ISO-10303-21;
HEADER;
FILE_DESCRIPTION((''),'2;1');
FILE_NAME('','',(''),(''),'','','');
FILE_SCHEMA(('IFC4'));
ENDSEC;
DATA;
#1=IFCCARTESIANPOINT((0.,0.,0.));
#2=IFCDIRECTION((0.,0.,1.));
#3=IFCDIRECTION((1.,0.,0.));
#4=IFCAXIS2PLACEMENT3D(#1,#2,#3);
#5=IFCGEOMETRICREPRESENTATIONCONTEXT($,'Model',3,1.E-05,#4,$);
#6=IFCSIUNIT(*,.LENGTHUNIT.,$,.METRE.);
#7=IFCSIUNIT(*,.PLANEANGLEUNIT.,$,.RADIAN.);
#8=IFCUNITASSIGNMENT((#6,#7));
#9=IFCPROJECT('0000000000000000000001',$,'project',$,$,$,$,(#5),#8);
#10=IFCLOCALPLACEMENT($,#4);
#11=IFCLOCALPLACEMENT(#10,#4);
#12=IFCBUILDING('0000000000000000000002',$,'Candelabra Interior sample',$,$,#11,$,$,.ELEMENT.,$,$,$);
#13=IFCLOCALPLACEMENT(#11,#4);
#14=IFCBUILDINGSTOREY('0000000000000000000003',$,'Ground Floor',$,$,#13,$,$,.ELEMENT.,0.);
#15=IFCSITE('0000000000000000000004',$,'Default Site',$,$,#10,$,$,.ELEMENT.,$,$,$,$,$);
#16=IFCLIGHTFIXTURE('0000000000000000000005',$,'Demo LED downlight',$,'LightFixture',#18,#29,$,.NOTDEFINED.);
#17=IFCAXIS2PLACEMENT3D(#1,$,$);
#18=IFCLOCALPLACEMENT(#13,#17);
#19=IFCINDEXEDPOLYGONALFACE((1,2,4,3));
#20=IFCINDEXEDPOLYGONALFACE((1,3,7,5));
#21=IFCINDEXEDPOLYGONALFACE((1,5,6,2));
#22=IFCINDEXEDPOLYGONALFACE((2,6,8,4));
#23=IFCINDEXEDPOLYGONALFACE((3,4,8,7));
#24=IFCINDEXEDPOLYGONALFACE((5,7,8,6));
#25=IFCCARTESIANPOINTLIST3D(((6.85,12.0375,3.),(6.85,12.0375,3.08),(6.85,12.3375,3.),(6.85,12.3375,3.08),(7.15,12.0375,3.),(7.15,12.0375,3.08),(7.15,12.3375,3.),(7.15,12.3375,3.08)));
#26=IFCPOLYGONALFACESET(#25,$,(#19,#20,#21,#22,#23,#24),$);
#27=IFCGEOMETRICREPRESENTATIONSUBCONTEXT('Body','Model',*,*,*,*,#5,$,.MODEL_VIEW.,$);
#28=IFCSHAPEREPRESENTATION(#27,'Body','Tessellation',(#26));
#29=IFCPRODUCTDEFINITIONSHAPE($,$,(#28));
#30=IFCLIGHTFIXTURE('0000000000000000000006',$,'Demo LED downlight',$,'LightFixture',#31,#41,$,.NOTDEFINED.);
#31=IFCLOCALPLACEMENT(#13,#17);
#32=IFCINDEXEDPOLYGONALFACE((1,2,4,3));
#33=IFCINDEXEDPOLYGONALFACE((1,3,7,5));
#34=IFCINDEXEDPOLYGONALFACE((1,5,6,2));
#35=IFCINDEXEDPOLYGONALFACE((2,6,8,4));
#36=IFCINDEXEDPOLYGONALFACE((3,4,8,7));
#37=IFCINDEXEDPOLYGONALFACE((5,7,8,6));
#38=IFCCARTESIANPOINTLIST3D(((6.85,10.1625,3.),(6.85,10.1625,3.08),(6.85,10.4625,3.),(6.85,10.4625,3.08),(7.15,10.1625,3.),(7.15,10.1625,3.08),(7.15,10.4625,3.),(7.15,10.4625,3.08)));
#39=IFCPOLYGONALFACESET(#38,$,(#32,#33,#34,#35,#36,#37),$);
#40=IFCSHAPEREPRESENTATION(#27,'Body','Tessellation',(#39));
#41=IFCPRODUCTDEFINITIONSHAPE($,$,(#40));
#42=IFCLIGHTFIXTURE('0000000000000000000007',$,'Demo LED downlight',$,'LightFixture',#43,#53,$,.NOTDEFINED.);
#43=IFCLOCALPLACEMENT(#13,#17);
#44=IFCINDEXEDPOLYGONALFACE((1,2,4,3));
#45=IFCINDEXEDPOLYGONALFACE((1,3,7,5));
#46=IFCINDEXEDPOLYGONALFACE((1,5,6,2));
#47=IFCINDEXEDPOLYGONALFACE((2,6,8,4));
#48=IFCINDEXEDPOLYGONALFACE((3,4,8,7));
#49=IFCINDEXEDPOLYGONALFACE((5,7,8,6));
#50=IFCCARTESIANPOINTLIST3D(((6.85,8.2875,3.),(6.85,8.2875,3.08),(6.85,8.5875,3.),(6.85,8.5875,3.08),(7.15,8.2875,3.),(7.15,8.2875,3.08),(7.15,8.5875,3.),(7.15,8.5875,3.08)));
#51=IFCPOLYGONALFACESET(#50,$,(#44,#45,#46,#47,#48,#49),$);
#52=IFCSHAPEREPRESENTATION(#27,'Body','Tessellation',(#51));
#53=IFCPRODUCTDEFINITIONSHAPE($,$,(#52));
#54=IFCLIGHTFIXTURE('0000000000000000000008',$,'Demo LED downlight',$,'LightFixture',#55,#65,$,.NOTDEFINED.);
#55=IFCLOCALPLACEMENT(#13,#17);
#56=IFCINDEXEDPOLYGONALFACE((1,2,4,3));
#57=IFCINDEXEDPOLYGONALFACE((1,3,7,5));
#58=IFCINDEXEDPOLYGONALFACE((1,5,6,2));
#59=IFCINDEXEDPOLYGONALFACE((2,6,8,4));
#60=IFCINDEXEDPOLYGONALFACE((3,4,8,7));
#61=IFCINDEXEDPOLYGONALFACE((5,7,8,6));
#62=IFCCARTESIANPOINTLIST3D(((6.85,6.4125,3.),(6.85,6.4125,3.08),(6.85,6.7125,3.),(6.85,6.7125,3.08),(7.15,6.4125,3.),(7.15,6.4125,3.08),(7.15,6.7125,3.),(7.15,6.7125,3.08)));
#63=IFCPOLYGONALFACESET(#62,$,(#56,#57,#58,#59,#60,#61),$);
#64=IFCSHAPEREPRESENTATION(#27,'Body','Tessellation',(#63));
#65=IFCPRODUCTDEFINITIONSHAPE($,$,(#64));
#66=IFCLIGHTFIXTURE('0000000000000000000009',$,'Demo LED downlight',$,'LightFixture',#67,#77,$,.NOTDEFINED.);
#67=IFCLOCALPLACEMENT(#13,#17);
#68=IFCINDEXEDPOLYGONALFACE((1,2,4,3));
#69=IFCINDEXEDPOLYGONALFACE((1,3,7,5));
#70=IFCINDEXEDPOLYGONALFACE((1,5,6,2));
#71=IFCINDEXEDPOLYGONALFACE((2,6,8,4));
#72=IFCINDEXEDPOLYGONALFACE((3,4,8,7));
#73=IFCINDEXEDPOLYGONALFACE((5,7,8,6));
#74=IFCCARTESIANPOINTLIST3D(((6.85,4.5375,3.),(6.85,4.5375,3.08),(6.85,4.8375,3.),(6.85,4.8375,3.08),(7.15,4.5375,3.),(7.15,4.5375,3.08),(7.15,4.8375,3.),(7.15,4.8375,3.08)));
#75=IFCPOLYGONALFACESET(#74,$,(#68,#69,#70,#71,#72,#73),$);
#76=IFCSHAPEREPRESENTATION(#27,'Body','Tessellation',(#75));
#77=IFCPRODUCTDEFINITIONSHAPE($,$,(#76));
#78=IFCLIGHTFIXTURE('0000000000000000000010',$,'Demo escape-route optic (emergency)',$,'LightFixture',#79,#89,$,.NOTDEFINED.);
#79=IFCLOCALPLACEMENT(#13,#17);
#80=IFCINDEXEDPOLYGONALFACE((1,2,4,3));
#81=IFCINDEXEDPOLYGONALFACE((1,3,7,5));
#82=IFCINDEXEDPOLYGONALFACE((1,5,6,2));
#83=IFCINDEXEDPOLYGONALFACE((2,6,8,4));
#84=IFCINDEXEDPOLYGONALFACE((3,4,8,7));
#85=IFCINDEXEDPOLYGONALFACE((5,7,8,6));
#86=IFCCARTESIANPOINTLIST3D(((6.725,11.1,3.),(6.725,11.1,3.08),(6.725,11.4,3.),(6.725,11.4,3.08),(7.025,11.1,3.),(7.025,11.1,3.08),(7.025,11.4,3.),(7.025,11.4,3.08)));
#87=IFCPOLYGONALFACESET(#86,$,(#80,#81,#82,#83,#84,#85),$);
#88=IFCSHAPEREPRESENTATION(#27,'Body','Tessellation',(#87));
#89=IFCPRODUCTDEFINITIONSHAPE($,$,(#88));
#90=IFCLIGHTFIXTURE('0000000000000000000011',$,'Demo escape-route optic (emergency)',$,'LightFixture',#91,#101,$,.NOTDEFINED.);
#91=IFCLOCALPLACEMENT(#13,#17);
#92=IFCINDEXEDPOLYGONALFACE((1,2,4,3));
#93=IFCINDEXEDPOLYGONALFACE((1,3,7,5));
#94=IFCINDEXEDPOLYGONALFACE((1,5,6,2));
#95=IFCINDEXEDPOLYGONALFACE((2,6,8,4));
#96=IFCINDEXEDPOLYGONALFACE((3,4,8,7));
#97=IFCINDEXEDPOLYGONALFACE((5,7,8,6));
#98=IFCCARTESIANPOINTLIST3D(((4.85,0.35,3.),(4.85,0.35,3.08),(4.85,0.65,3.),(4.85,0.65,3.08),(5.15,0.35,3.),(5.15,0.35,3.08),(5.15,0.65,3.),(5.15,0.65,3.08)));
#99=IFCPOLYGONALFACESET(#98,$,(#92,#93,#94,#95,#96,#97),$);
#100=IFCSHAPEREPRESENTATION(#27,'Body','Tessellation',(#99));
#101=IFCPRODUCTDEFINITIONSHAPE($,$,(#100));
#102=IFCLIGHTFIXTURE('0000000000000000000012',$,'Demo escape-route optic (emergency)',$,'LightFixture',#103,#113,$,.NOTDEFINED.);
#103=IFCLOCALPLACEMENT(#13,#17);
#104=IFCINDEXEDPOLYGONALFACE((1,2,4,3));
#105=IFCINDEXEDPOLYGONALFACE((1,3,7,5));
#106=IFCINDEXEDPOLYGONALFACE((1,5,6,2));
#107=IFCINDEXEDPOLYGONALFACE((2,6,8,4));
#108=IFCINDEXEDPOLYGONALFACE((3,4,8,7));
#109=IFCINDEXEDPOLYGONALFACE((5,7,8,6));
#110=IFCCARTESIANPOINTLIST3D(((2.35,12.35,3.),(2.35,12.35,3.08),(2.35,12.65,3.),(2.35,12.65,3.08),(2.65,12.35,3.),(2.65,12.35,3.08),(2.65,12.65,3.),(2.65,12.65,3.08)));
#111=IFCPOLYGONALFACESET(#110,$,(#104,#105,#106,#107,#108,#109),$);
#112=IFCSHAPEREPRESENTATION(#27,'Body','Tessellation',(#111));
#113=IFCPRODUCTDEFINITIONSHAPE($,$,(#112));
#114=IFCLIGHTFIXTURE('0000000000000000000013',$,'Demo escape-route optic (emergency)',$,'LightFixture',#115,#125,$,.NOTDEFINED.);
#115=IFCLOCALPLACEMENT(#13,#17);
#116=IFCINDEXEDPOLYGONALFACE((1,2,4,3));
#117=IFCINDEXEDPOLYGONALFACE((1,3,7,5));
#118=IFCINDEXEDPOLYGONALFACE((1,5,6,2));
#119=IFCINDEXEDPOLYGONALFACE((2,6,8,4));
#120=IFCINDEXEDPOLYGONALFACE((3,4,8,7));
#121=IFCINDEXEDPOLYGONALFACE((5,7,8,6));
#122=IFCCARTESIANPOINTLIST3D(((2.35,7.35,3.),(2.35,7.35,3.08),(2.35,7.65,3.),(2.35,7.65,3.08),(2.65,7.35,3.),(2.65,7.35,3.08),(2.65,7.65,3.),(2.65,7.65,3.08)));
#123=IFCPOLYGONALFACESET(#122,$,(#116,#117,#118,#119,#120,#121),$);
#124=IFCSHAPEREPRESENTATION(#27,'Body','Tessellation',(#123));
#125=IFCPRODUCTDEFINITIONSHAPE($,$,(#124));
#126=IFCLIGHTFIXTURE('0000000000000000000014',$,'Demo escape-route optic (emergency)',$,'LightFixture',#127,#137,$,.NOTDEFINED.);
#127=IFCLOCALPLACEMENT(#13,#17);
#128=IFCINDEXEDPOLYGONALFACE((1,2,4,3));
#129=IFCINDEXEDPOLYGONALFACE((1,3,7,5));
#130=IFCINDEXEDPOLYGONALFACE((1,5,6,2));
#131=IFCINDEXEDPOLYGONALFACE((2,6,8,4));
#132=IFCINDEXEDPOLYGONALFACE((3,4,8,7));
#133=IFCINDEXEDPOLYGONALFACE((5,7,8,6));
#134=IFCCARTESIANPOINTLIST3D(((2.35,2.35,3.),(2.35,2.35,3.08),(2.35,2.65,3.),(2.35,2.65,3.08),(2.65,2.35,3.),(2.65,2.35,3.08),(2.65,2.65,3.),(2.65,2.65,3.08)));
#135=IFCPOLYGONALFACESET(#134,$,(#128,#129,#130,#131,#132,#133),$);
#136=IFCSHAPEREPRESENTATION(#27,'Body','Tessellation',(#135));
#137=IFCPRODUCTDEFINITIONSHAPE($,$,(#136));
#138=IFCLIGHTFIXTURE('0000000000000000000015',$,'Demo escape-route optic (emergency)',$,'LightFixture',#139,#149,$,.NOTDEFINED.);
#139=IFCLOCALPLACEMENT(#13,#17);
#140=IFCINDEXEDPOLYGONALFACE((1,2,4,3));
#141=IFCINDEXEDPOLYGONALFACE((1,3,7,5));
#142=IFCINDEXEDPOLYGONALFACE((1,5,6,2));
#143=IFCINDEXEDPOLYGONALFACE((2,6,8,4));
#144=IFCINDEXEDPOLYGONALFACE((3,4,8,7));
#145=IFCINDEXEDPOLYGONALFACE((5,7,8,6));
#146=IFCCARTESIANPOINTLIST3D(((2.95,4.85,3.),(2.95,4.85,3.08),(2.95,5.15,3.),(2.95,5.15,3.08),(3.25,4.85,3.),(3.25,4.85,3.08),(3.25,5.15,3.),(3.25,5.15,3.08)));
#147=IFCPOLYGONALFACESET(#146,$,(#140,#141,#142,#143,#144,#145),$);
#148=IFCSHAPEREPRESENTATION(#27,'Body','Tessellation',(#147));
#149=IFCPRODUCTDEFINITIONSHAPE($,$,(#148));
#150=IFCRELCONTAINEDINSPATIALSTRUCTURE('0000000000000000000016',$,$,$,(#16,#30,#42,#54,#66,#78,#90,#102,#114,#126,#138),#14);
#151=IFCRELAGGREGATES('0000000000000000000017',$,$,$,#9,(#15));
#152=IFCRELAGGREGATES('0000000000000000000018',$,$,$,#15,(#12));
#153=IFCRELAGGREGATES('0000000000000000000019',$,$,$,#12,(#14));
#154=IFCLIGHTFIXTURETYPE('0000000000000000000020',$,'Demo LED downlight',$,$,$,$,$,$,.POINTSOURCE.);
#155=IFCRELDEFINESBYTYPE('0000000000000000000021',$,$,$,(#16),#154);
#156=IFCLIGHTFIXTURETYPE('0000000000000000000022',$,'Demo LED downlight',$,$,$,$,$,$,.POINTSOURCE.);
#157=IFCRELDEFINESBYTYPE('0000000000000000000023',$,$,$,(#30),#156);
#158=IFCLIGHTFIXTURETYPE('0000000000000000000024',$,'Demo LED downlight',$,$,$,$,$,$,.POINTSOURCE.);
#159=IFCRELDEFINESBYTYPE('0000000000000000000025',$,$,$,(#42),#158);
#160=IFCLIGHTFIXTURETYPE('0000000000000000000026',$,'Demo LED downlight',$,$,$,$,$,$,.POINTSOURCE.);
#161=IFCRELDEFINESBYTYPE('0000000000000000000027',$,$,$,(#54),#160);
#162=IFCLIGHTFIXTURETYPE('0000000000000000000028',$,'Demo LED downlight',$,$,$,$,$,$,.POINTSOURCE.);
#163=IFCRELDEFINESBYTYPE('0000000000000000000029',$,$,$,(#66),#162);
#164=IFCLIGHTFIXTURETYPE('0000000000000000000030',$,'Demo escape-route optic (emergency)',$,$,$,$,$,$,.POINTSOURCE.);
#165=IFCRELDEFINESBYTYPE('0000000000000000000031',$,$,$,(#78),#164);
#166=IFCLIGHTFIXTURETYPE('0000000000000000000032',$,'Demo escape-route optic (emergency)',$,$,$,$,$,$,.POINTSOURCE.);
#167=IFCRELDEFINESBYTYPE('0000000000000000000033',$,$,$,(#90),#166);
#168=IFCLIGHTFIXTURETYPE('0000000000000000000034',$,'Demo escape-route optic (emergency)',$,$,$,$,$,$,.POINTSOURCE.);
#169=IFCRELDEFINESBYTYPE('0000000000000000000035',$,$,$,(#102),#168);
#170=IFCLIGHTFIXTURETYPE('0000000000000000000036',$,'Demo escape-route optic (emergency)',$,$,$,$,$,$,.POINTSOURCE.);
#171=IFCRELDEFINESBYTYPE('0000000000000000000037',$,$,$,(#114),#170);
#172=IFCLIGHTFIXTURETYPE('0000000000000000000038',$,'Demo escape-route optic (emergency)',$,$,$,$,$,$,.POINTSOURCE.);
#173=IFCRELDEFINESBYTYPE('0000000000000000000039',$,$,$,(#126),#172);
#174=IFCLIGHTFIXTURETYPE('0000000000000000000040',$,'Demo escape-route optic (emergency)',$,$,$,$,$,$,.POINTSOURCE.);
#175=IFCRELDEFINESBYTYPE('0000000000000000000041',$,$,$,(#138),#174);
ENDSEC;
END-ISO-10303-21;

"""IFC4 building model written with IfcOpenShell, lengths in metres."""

from ifc_helpers import new_model, si_unit, frame, origin_with_axes, place, context, subcontext, project, spatial, polyline, outline, extrude, type_object, element, save


model = new_model("IFC4")

# Units and contexts
model_context = context("Model", 3, precision=1e-05, world=origin_with_axes())
body_context = subcontext(model_context, "Body", "Model", "MODEL_VIEW")
ifc_project = project(units=[si_unit("LENGTHUNIT", "METRE"), si_unit("PLANEANGLEUNIT", "RADIAN")], contexts=[model_context])

# Site, building, storey
site_placement = place(None, origin_with_axes())
site = spatial("IfcSite", under=ifc_project, at=site_placement, Name="Default Site", CompositionType="ELEMENT")
building_placement = place(site_placement, origin_with_axes())
building = spatial("IfcBuilding", under=site, at=building_placement, Name="Candelabra Interior sample", CompositionType="ELEMENT")
storey_placement = place(building_placement, origin_with_axes())
storey = spatial("IfcBuildingStorey", under=building, at=storey_placement, Name="Ground Floor", CompositionType="ELEMENT", Elevation=0.0)

# Light fixtures
light_fixture_type_1 = type_object("IfcLightFixtureType", Name="Demo LED downlight", PredefinedType="POINTSOURCE")
light_fixture_1_placement = place(storey_placement, frame((7.0, 12.1875, 3.08), z_axis=(0.0, 0.0, 1.0), x_axis=(1.0, 0.0, 0.0)))
element("IfcLightFixture", 1, at=light_fixture_1_placement, inside=storey, type_object=light_fixture_type_1, Name="Demo LED downlight", ObjectType="LightFixture", PredefinedType="NOTDEFINED", context=body_context, shape_type="SweptSolid", body=[
    extrude(outline(polyline([(0.15, 0.15), (-0.15, 0.15), (-0.15, -0.15), (0.15, -0.15), (0.15, 0.15)])), origin_with_axes(), (0.0, 0.0, -1.0), 0.08),
])
light_fixture_type_2 = type_object("IfcLightFixtureType", Name="Demo LED downlight", PredefinedType="POINTSOURCE")
light_fixture_2_placement = place(storey_placement, frame((7.0, 10.3125, 3.08), z_axis=(0.0, 0.0, 1.0), x_axis=(1.0, 0.0, 0.0)))
element("IfcLightFixture", 2, at=light_fixture_2_placement, inside=storey, type_object=light_fixture_type_2, Name="Demo LED downlight", ObjectType="LightFixture", PredefinedType="NOTDEFINED", context=body_context, shape_type="SweptSolid", body=[
    extrude(outline(polyline([(0.15, 0.15), (-0.15, 0.15), (-0.15, -0.15), (0.15, -0.15), (0.15, 0.15)])), origin_with_axes(), (0.0, 0.0, -1.0), 0.08),
])
light_fixture_type_3 = type_object("IfcLightFixtureType", Name="Demo LED downlight", PredefinedType="POINTSOURCE")
light_fixture_3_placement = place(storey_placement, frame((7.0, 8.4375, 3.08), z_axis=(0.0, 0.0, 1.0), x_axis=(1.0, 0.0, 0.0)))
element("IfcLightFixture", 3, at=light_fixture_3_placement, inside=storey, type_object=light_fixture_type_3, Name="Demo LED downlight", ObjectType="LightFixture", PredefinedType="NOTDEFINED", context=body_context, shape_type="SweptSolid", body=[
    extrude(outline(polyline([(0.15, 0.15), (-0.15, 0.15), (-0.15, -0.15), (0.15, -0.15), (0.15, 0.15)])), origin_with_axes(), (0.0, 0.0, -1.0), 0.08),
])
light_fixture_type_4 = type_object("IfcLightFixtureType", Name="Demo LED downlight", PredefinedType="POINTSOURCE")
light_fixture_4_placement = place(storey_placement, frame((7.0, 6.5625, 3.08), z_axis=(0.0, 0.0, 1.0), x_axis=(1.0, 0.0, 0.0)))
element("IfcLightFixture", 4, at=light_fixture_4_placement, inside=storey, type_object=light_fixture_type_4, Name="Demo LED downlight", ObjectType="LightFixture", PredefinedType="NOTDEFINED", context=body_context, shape_type="SweptSolid", body=[
    extrude(outline(polyline([(0.15, 0.15), (-0.15, 0.15), (-0.15, -0.15), (0.15, -0.15), (0.15, 0.15)])), origin_with_axes(), (0.0, 0.0, -1.0), 0.08),
])
light_fixture_type_5 = type_object("IfcLightFixtureType", Name="Demo LED downlight", PredefinedType="POINTSOURCE")
light_fixture_5_placement = place(storey_placement, frame((7.0, 4.6875, 3.08), z_axis=(0.0, 0.0, 1.0), x_axis=(1.0, 0.0, 0.0)))
element("IfcLightFixture", 5, at=light_fixture_5_placement, inside=storey, type_object=light_fixture_type_5, Name="Demo LED downlight", ObjectType="LightFixture", PredefinedType="NOTDEFINED", context=body_context, shape_type="SweptSolid", body=[
    extrude(outline(polyline([(0.15, 0.15), (-0.15, 0.15), (-0.15, -0.15), (0.15, -0.15), (0.15, 0.15)])), origin_with_axes(), (0.0, 0.0, -1.0), 0.08),
])
light_fixture_type_6 = type_object("IfcLightFixtureType", Name="Demo escape-route optic (emergency)", PredefinedType="POINTSOURCE")
light_fixture_6_placement = place(storey_placement, frame((6.875, 11.25, 3.08), z_axis=(0.0, 0.0, 1.0), x_axis=(-1.0, 0.0, 0.0)))
element("IfcLightFixture", 6, at=light_fixture_6_placement, inside=storey, type_object=light_fixture_type_6, Name="Demo escape-route optic (emergency)", ObjectType="LightFixture", PredefinedType="NOTDEFINED", context=body_context, shape_type="SweptSolid", body=[
    extrude(outline(polyline([(0.15, 0.15), (-0.15, 0.15), (-0.15, -0.15), (0.15, -0.15), (0.15, 0.15)])), origin_with_axes(), (0.0, 0.0, -1.0), 0.08),
])
light_fixture_type_7 = type_object("IfcLightFixtureType", Name="Demo escape-route optic (emergency)", PredefinedType="POINTSOURCE")
light_fixture_7_placement = place(storey_placement, frame((5.0, 0.5, 3.08), z_axis=(0.0, 0.0, 1.0), x_axis=(0.0, -1.0, 0.0)))
element("IfcLightFixture", 7, at=light_fixture_7_placement, inside=storey, type_object=light_fixture_type_7, Name="Demo escape-route optic (emergency)", ObjectType="LightFixture", PredefinedType="NOTDEFINED", context=body_context, shape_type="SweptSolid", body=[
    extrude(outline(polyline([(0.15, 0.15), (-0.15, 0.15), (-0.15, -0.15), (0.15, -0.15), (0.15, 0.15)])), origin_with_axes(), (0.0, 0.0, -1.0), 0.08),
])
light_fixture_type_8 = type_object("IfcLightFixtureType", Name="Demo escape-route optic (emergency)", PredefinedType="POINTSOURCE")
light_fixture_8_placement = place(storey_placement, frame((2.5, 12.5, 3.08), z_axis=(0.0, 0.0, 1.0), x_axis=(1.0, 0.0, 0.0)))
element("IfcLightFixture", 8, at=light_fixture_8_placement, inside=storey, type_object=light_fixture_type_8, Name="Demo escape-route optic (emergency)", ObjectType="LightFixture", PredefinedType="NOTDEFINED", context=body_context, shape_type="SweptSolid", body=[
    extrude(outline(polyline([(0.15, 0.15), (-0.15, 0.15), (-0.15, -0.15), (0.15, -0.15), (0.15, 0.15)])), origin_with_axes(), (0.0, 0.0, -1.0), 0.08),
])
light_fixture_type_9 = type_object("IfcLightFixtureType", Name="Demo escape-route optic (emergency)", PredefinedType="POINTSOURCE")
light_fixture_9_placement = place(storey_placement, frame((2.5, 7.5, 3.08), z_axis=(0.0, 0.0, 1.0), x_axis=(1.0, 0.0, 0.0)))
element("IfcLightFixture", 9, at=light_fixture_9_placement, inside=storey, type_object=light_fixture_type_9, Name="Demo escape-route optic (emergency)", ObjectType="LightFixture", PredefinedType="NOTDEFINED", context=body_context, shape_type="SweptSolid", body=[
    extrude(outline(polyline([(0.15, 0.15), (-0.15, 0.15), (-0.15, -0.15), (0.15, -0.15), (0.15, 0.15)])), origin_with_axes(), (0.0, 0.0, -1.0), 0.08),
])
light_fixture_type_10 = type_object("IfcLightFixtureType", Name="Demo escape-route optic (emergency)", PredefinedType="POINTSOURCE")
light_fixture_10_placement = place(storey_placement, frame((2.5, 2.5, 3.08), z_axis=(0.0, 0.0, 1.0), x_axis=(1.0, 0.0, 0.0)))
element("IfcLightFixture", 10, at=light_fixture_10_placement, inside=storey, type_object=light_fixture_type_10, Name="Demo escape-route optic (emergency)", ObjectType="LightFixture", PredefinedType="NOTDEFINED", context=body_context, shape_type="SweptSolid", body=[
    extrude(outline(polyline([(0.15, 0.15), (-0.15, 0.15), (-0.15, -0.15), (0.15, -0.15), (0.15, 0.15)])), origin_with_axes(), (0.0, 0.0, -1.0), 0.08),
])
light_fixture_type_11 = type_object("IfcLightFixtureType", Name="Demo escape-route optic (emergency)", PredefinedType="POINTSOURCE")
light_fixture_11_placement = place(storey_placement, frame((3.1, 5.0, 3.08), z_axis=(0.0, 0.0, 1.0), x_axis=(-1.0, 0.0, 0.0)))
element("IfcLightFixture", 11, at=light_fixture_11_placement, inside=storey, type_object=light_fixture_type_11, Name="Demo escape-route optic (emergency)", ObjectType="LightFixture", PredefinedType="NOTDEFINED", context=body_context, shape_type="SweptSolid", body=[
    extrude(outline(polyline([(0.15, 0.15), (-0.15, 0.15), (-0.15, -0.15), (0.15, -0.15), (0.15, 0.15)])), origin_with_axes(), (0.0, 0.0, -1.0), 0.08),
])

save(model, "model.ifc")
